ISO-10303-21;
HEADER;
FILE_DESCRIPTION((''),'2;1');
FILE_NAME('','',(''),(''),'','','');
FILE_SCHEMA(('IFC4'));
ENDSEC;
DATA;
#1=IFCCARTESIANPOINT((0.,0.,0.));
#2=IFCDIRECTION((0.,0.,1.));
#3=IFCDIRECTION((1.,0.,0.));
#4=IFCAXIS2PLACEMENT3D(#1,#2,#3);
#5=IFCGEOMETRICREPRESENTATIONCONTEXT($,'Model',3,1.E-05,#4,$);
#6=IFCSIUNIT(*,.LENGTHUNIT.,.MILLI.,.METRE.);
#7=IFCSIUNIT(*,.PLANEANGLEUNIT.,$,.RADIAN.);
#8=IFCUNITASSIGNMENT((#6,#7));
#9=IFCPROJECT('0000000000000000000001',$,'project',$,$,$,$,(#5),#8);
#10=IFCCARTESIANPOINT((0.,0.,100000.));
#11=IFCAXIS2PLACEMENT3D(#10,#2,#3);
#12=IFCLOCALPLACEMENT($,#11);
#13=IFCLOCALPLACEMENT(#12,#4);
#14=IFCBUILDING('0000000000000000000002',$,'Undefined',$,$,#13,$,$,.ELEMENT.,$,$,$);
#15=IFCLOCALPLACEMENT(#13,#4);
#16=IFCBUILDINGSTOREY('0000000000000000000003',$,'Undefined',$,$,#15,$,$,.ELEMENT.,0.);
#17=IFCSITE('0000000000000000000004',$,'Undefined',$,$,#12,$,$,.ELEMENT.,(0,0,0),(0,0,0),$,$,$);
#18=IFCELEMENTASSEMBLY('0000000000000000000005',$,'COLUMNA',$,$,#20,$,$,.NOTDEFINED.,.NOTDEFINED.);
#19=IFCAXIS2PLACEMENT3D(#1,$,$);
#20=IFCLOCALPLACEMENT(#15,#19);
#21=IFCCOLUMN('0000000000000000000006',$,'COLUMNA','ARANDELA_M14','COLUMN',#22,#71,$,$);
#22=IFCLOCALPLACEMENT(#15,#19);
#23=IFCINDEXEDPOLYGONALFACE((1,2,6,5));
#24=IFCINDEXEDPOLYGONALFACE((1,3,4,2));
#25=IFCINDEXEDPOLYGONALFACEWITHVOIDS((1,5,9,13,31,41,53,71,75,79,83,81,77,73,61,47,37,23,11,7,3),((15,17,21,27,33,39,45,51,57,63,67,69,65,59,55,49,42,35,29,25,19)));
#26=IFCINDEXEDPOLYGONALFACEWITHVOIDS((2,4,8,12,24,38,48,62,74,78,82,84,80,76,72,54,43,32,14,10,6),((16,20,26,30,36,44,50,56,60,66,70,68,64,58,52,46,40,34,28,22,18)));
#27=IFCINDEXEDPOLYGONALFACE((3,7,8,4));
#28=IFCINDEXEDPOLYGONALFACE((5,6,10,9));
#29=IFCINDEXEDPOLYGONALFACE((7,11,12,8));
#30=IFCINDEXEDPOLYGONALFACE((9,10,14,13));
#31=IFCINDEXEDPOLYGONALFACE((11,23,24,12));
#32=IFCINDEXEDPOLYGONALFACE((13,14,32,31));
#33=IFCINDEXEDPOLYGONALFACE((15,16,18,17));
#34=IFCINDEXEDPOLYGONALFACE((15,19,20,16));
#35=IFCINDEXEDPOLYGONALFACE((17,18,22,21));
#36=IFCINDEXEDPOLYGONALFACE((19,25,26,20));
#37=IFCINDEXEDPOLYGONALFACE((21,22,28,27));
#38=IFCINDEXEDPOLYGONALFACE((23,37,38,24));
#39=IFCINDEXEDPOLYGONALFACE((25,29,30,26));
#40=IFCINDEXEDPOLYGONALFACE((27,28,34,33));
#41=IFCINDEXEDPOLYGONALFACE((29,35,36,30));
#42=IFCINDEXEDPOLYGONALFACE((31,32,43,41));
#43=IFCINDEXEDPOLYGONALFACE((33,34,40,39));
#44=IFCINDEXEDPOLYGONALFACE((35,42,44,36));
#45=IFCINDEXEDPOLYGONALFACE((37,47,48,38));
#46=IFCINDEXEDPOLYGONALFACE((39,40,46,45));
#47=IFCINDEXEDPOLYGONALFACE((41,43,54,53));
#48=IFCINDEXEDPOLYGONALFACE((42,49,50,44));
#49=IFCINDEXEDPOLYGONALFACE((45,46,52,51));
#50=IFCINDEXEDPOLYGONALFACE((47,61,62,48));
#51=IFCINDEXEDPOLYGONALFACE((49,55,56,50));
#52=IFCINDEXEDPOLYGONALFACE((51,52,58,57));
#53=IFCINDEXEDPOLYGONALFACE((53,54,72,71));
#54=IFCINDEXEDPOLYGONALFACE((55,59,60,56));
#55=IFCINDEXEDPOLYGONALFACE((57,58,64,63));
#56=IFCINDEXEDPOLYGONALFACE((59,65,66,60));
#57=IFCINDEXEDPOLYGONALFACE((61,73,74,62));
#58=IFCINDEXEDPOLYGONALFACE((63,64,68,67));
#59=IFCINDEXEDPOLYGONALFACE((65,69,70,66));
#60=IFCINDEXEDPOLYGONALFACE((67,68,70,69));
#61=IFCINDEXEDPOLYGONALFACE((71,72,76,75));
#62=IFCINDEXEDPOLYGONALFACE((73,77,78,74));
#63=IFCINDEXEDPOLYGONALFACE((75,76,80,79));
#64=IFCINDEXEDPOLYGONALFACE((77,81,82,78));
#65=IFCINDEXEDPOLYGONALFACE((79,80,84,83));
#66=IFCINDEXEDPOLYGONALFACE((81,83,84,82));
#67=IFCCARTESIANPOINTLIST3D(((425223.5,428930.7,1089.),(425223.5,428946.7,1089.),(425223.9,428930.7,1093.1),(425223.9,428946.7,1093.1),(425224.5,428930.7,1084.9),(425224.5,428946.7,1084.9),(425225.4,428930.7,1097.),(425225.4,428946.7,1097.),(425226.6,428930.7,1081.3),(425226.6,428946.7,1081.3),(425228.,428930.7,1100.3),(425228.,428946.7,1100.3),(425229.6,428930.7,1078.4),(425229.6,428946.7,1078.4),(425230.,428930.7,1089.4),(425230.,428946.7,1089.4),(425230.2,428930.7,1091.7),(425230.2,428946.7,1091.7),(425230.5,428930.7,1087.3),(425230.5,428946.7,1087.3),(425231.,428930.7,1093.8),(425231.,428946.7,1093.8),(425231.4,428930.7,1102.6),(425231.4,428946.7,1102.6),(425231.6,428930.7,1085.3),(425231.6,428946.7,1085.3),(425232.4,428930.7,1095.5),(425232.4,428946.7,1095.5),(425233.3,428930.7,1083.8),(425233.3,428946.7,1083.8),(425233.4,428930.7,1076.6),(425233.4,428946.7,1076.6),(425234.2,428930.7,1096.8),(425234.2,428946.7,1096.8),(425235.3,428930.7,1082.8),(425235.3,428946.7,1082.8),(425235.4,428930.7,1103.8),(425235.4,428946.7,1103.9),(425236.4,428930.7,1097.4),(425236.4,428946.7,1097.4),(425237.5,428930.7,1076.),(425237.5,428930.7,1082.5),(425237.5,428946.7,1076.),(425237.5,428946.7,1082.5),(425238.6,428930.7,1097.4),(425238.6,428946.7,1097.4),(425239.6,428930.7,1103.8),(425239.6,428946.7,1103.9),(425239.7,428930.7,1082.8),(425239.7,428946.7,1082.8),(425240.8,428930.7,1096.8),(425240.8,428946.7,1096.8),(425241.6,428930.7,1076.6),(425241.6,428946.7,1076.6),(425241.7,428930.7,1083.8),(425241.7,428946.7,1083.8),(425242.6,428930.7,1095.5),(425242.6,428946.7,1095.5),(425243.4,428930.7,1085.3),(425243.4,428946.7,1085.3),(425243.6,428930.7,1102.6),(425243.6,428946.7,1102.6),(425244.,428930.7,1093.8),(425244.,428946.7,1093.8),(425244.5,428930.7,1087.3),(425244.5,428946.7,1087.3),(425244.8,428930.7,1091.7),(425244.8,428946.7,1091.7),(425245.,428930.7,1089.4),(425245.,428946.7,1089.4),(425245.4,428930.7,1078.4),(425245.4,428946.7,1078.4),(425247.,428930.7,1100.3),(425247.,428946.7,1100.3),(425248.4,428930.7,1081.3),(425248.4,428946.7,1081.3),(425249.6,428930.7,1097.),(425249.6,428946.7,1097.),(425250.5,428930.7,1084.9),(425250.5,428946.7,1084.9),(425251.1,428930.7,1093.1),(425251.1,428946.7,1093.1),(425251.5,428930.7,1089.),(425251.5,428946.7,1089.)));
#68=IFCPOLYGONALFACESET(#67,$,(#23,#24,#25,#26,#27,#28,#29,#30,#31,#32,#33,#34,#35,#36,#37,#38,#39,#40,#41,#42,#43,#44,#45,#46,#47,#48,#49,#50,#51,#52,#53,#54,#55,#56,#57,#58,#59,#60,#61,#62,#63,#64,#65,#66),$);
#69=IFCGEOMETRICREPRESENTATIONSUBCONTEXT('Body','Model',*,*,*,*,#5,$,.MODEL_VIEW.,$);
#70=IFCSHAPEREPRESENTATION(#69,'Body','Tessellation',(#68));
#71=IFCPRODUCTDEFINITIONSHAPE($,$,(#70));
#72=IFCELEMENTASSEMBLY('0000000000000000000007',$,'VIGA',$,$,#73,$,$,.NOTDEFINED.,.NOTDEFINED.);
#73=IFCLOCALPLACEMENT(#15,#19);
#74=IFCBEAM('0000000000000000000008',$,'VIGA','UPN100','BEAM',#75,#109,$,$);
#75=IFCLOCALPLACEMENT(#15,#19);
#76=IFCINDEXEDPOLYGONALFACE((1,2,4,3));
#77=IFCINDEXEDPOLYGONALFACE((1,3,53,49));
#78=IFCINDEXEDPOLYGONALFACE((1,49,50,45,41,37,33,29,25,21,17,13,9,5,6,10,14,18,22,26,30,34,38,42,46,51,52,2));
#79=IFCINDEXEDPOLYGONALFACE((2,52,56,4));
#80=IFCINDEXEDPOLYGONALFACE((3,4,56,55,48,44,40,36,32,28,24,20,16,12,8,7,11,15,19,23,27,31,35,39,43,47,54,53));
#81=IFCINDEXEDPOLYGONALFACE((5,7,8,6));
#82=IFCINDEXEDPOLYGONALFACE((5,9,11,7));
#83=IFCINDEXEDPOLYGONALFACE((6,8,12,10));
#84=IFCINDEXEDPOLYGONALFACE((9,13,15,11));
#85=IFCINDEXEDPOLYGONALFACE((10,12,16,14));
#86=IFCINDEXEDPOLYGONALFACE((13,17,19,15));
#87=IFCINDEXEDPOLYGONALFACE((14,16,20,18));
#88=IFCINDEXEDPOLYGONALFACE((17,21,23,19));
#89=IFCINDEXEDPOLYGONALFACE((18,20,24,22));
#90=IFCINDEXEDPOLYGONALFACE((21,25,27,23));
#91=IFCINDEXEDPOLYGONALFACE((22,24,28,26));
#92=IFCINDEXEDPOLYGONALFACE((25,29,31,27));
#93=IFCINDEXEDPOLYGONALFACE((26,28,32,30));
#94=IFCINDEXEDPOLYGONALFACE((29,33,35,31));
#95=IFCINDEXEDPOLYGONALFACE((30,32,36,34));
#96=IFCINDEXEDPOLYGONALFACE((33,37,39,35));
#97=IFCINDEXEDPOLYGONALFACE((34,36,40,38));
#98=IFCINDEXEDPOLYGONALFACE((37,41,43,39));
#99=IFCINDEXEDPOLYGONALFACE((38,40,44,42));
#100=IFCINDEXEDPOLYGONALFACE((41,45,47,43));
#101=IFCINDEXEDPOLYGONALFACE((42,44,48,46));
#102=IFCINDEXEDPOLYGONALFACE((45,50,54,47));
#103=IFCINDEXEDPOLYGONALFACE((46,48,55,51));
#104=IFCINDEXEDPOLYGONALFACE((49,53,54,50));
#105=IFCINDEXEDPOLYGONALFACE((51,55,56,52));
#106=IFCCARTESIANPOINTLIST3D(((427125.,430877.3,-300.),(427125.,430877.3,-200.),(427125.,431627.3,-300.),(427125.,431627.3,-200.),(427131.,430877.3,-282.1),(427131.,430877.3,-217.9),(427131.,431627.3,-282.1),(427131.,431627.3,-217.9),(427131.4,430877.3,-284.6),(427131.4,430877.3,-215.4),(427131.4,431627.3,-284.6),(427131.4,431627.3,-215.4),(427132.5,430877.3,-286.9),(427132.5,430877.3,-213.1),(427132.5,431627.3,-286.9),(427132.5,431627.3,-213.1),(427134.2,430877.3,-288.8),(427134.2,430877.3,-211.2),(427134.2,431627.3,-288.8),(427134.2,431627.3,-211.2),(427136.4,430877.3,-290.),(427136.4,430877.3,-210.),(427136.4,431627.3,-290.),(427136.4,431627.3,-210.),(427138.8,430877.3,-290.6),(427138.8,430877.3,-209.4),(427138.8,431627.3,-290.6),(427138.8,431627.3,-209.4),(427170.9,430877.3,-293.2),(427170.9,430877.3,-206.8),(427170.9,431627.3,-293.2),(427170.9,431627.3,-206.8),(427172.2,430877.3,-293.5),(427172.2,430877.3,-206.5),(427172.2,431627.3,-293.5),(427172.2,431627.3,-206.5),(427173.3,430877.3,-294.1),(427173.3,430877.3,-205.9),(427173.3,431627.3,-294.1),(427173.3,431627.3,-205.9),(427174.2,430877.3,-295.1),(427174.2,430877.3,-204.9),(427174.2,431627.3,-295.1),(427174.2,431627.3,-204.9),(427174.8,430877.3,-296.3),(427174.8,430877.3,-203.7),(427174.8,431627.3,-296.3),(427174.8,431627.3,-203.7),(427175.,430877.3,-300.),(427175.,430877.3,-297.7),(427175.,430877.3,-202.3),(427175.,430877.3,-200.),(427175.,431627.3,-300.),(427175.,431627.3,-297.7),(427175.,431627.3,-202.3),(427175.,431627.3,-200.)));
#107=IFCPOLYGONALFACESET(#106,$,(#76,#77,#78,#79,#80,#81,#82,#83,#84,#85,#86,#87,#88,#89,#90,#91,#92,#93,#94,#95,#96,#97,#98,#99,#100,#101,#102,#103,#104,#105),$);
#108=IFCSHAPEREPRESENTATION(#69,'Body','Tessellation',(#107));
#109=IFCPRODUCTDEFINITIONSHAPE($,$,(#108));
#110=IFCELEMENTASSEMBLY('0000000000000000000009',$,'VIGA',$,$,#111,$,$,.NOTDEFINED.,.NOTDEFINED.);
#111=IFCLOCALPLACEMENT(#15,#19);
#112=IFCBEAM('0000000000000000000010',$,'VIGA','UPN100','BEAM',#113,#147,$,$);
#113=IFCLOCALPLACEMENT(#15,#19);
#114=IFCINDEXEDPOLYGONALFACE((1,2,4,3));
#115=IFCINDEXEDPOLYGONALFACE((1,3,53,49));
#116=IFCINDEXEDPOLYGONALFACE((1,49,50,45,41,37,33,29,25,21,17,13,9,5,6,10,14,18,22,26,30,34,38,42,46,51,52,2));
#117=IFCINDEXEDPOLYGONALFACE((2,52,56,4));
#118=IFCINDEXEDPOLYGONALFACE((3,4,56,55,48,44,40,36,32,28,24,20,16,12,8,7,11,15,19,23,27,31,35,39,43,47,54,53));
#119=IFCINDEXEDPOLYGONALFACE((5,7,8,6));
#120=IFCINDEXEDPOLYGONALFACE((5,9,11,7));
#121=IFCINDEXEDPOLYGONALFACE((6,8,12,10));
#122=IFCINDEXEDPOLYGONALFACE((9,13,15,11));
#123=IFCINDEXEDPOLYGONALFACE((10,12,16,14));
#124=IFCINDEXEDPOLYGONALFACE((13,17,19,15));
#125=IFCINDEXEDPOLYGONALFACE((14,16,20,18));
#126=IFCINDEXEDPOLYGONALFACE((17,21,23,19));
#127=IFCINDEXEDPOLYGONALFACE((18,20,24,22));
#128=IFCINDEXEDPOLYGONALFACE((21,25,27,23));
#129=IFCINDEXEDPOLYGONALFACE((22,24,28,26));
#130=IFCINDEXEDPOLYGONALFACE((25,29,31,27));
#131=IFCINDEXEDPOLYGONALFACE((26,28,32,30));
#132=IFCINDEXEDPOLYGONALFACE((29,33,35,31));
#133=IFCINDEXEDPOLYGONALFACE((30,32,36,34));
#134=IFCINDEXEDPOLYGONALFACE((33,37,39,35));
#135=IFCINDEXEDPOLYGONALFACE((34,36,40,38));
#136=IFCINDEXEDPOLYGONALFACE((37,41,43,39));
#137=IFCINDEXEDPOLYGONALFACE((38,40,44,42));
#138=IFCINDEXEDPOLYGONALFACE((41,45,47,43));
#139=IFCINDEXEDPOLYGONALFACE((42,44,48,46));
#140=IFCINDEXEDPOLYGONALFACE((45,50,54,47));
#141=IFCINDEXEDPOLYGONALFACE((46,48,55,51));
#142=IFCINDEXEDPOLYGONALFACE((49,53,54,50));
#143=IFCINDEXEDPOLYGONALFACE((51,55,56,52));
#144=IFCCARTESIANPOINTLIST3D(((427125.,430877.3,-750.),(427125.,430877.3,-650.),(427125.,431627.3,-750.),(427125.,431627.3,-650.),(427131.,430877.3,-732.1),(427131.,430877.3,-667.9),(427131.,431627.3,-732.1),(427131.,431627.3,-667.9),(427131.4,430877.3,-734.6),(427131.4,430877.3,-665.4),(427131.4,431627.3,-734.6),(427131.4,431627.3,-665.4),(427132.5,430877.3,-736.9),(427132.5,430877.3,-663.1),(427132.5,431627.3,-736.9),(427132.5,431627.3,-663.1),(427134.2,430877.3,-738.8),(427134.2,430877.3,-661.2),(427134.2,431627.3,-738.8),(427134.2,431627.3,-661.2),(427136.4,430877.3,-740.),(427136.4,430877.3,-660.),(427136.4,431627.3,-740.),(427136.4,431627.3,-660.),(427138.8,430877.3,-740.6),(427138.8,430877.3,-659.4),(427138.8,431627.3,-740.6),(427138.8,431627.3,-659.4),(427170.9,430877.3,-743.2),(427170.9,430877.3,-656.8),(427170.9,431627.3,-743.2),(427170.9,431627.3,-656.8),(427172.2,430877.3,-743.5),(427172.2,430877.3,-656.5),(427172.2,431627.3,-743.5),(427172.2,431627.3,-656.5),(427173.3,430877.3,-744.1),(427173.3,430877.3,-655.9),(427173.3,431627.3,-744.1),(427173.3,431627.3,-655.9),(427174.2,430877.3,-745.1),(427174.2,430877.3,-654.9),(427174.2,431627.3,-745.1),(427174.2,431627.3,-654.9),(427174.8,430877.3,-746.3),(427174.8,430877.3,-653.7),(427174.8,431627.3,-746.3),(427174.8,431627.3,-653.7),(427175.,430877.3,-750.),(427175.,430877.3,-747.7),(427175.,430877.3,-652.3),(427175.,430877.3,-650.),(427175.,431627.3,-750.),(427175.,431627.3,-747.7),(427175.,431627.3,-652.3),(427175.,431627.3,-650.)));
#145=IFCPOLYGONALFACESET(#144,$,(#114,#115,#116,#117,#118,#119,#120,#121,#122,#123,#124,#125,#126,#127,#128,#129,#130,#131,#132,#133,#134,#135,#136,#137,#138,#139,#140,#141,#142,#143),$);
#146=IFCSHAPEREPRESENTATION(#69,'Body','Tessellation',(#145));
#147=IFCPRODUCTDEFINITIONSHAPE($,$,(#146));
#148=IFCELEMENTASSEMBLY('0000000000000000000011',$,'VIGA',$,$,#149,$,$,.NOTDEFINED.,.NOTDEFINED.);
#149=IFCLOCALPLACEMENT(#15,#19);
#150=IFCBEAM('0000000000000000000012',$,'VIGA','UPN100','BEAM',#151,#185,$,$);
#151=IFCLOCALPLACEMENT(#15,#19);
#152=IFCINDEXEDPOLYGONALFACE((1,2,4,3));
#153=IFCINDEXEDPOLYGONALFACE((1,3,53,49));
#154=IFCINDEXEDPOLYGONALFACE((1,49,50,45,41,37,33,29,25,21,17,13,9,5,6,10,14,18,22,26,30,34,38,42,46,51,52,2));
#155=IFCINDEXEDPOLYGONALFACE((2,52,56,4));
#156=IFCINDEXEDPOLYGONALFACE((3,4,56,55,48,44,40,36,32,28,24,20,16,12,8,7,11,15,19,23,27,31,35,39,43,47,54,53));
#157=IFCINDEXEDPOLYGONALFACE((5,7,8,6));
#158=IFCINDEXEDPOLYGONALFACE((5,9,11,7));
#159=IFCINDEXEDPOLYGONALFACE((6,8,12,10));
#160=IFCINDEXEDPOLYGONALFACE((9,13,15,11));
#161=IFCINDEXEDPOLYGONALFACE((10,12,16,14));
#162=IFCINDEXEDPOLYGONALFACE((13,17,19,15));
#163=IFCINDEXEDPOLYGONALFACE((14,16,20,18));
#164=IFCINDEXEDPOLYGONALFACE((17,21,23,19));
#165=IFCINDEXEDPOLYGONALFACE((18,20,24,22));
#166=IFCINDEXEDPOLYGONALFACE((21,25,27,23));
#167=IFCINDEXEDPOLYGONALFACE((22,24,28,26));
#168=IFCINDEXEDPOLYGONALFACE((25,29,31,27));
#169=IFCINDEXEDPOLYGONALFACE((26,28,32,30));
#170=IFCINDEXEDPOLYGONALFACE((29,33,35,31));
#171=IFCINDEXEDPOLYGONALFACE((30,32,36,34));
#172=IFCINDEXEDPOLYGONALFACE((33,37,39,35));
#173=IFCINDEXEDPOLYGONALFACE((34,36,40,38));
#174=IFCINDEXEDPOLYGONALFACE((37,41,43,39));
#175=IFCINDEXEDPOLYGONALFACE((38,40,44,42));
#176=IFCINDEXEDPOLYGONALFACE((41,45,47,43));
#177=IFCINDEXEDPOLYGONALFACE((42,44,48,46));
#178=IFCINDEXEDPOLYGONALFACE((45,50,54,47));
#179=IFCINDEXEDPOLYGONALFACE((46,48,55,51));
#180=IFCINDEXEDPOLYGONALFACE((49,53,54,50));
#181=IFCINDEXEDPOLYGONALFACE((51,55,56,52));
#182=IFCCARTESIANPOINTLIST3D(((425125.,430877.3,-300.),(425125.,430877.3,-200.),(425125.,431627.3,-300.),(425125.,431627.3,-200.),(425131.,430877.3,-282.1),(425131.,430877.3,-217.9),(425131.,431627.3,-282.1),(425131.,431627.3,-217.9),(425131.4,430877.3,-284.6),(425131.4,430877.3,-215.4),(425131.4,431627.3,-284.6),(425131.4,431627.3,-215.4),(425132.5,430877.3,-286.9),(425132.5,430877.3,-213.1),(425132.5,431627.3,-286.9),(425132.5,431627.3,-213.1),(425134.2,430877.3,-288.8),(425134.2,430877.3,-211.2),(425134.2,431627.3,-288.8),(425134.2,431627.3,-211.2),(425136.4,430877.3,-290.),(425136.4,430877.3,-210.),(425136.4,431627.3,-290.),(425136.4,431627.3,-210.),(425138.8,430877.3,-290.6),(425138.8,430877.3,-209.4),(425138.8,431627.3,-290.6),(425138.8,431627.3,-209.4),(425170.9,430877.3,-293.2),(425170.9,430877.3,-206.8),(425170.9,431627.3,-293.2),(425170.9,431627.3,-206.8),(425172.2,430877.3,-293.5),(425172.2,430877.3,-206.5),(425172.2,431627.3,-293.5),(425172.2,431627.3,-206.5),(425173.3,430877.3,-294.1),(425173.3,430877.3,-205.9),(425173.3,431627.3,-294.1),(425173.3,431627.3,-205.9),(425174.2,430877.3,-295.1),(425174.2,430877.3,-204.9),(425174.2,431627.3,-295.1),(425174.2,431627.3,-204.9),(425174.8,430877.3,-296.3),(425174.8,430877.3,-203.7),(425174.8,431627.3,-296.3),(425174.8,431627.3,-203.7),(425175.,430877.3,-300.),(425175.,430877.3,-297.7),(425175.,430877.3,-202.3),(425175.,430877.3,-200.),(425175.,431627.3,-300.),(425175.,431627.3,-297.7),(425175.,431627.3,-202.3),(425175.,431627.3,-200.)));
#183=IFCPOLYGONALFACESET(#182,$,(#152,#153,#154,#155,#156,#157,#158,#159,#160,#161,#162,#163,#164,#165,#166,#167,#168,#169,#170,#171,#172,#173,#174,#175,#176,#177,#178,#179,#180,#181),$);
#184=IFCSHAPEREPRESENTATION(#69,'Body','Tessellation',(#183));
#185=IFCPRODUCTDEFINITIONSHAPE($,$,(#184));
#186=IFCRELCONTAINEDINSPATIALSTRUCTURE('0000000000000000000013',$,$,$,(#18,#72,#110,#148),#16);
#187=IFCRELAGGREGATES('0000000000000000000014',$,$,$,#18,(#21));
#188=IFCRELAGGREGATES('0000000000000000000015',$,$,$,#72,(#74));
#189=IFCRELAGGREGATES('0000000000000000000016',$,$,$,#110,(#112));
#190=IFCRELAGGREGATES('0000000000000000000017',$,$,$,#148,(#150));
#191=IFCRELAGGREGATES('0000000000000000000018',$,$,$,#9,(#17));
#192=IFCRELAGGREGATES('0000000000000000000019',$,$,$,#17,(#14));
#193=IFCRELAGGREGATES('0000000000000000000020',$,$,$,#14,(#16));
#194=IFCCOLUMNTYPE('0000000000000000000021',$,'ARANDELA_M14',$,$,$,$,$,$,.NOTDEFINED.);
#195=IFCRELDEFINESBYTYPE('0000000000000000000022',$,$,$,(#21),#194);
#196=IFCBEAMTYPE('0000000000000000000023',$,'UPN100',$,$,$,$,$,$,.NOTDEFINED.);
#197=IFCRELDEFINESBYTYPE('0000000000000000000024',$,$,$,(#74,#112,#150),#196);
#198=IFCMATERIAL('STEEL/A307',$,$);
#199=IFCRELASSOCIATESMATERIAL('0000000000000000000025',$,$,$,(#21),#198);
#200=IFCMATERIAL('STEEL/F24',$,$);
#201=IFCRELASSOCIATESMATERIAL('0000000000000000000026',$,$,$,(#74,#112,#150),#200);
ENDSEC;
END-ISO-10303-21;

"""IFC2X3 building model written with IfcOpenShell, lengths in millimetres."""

from ifc_helpers import new_model, si_unit, frame, origin_with_axes, origin_2d_with_axis, place, context, subcontext, project, spatial, hollow_circle, u_section, extrude, material, type_object, element, aggregate, save


model = new_model("IFC2X3")

# Units and contexts
model_context = context("Model", 3, precision=1e-05, world=origin_with_axes())
body_context = subcontext(model_context, "Body", "Model", "MODEL_VIEW")
ifc_project = project(units=[si_unit("LENGTHUNIT", "METRE", prefix="MILLI"), si_unit("PLANEANGLEUNIT", "RADIAN")], contexts=[model_context])

# Site, building, storey
site_placement = place(None, frame((0.0, 0.0, 100000.0), z_axis=(0.0, 0.0, 1.0), x_axis=(1.0, 0.0, 0.0)))
site = spatial("IfcSite", under=ifc_project, at=site_placement, Name="Undefined", CompositionType="ELEMENT", RefLatitude=(0, 0, 0), RefLongitude=(0, 0, 0))
building_placement = place(site_placement, origin_with_axes())
building = spatial("IfcBuilding", under=site, at=building_placement, Name="Undefined", CompositionType="ELEMENT")
storey_placement = place(building_placement, origin_with_axes())
storey = spatial("IfcBuildingStorey", under=building, at=storey_placement, Name="Undefined", CompositionType="ELEMENT", Elevation=0.0)

# Element assembly, column
ifc_material_1 = material(Name="STEEL/A307")
column_type = type_object("IfcColumnType", Name="ARANDELA_M14", PredefinedType="NOTDEFINED")
assembly_1_placement = place(storey_placement, origin_with_axes())
assembly_1 = element("IfcElementAssembly", 1, at=assembly_1_placement, inside=storey, Name="COLUMNA", AssemblyPlace="NOTDEFINED", PredefinedType="NOTDEFINED")
column_1_placement = place(assembly_1_placement, frame((425237.5, 428930.7, 1090.0), z_axis=(0.0, 1.0, 0.000285), x_axis=(1.0, 0.0, 0.0)))
column_1 = element("IfcColumn", 2, at=column_1_placement, type_object=column_type, material=ifc_material_1, Name="COLUMNA", Description="ARANDELA_M14", ObjectType="COLUMN", context=body_context, shape_type="SweptSolid", body=[
    extrude(hollow_circle(Radius=14.0, WallThickness=6.5, at=origin_2d_with_axis()), frame((0.0, 0.0, 16.0), z_axis=(0.0, 0.0, -1.0), x_axis=(0.0, 1.0, 0.0)), (0.0, 0.0, 1.0), 16.0),
])
aggregate(assembly_1, [column_1])

# Element assemblies, beams
assembly_2_placement = place(storey_placement, origin_with_axes())
assembly_2 = element("IfcElementAssembly", 3, at=assembly_2_placement, inside=storey, Name="VIGA", AssemblyPlace="NOTDEFINED", PredefinedType="NOTDEFINED")
ifc_material_2 = material(Name="STEEL/F24")
beam_type = type_object("IfcBeamType", Name="UPN100", PredefinedType="NOTDEFINED")
beam_1_placement = place(assembly_2_placement, frame((427150.0, 430877.3, -250.0), z_axis=(0.0, 0.0, 1.0), x_axis=(0.0, 1.0, 0.0)))
beam_1 = element("IfcBeam", 4, at=beam_1_placement, type_object=beam_type, material=ifc_material_2, Name="VIGA", Description="UPN100", ObjectType="BEAM", context=body_context, shape_type="SweptSolid", body=[
    extrude(u_section(Depth=100.0, FlangeWidth=50.0, WebThickness=6.0, FlangeThickness=8.5, FilletRadius=8.5, EdgeRadius=4.5, FlangeSlope=0.07983, at=origin_2d_with_axis()), frame((750.0, 0.0, 0.0), z_axis=(-1.0, 0.0, 0.0), x_axis=(0.0, -1.0, 0.0)), (0.0, 0.0, 1.0), 750.0),
])
aggregate(assembly_2, [beam_1])
assembly_3_placement = place(storey_placement, origin_with_axes())
assembly_3 = element("IfcElementAssembly", 5, at=assembly_3_placement, inside=storey, Name="VIGA", AssemblyPlace="NOTDEFINED", PredefinedType="NOTDEFINED")
beam_2_placement = place(assembly_3_placement, frame((427150.0, 430877.3, -700.0), z_axis=(0.0, 0.0, 1.0), x_axis=(0.0, 1.0, 0.0)))
beam_2 = element("IfcBeam", 6, at=beam_2_placement, type_object=beam_type, material=ifc_material_2, Name="VIGA", Description="UPN100", ObjectType="BEAM", context=body_context, shape_type="SweptSolid", body=[
    extrude(u_section(Depth=100.0, FlangeWidth=50.0, WebThickness=6.0, FlangeThickness=8.5, FilletRadius=8.5, EdgeRadius=4.5, FlangeSlope=0.07983, at=origin_2d_with_axis()), frame((750.0, 0.0, 0.0), z_axis=(-1.0, 0.0, 0.0), x_axis=(0.0, -1.0, 0.0)), (0.0, 0.0, 1.0), 750.0),
])
aggregate(assembly_3, [beam_2])
assembly_4_placement = place(storey_placement, origin_with_axes())
assembly_4 = element("IfcElementAssembly", 7, at=assembly_4_placement, inside=storey, Name="VIGA", AssemblyPlace="NOTDEFINED", PredefinedType="NOTDEFINED")
beam_3_placement = place(assembly_4_placement, frame((425150.0, 430877.3, -250.0), z_axis=(0.0, 0.0, 1.0), x_axis=(0.0, 1.0, 0.0)))
beam_3 = element("IfcBeam", 8, at=beam_3_placement, type_object=beam_type, material=ifc_material_2, Name="VIGA", Description="UPN100", ObjectType="BEAM", context=body_context, shape_type="SweptSolid", body=[
    extrude(u_section(Depth=100.0, FlangeWidth=50.0, WebThickness=6.0, FlangeThickness=8.5, FilletRadius=8.5, EdgeRadius=4.5, FlangeSlope=0.07983, at=origin_2d_with_axis()), frame((750.0, 0.0, 0.0), z_axis=(-1.0, 0.0, 0.0), x_axis=(0.0, -1.0, 0.0)), (0.0, 0.0, 1.0), 750.0),
])
aggregate(assembly_4, [beam_3])

save(model, "model.ifc")
